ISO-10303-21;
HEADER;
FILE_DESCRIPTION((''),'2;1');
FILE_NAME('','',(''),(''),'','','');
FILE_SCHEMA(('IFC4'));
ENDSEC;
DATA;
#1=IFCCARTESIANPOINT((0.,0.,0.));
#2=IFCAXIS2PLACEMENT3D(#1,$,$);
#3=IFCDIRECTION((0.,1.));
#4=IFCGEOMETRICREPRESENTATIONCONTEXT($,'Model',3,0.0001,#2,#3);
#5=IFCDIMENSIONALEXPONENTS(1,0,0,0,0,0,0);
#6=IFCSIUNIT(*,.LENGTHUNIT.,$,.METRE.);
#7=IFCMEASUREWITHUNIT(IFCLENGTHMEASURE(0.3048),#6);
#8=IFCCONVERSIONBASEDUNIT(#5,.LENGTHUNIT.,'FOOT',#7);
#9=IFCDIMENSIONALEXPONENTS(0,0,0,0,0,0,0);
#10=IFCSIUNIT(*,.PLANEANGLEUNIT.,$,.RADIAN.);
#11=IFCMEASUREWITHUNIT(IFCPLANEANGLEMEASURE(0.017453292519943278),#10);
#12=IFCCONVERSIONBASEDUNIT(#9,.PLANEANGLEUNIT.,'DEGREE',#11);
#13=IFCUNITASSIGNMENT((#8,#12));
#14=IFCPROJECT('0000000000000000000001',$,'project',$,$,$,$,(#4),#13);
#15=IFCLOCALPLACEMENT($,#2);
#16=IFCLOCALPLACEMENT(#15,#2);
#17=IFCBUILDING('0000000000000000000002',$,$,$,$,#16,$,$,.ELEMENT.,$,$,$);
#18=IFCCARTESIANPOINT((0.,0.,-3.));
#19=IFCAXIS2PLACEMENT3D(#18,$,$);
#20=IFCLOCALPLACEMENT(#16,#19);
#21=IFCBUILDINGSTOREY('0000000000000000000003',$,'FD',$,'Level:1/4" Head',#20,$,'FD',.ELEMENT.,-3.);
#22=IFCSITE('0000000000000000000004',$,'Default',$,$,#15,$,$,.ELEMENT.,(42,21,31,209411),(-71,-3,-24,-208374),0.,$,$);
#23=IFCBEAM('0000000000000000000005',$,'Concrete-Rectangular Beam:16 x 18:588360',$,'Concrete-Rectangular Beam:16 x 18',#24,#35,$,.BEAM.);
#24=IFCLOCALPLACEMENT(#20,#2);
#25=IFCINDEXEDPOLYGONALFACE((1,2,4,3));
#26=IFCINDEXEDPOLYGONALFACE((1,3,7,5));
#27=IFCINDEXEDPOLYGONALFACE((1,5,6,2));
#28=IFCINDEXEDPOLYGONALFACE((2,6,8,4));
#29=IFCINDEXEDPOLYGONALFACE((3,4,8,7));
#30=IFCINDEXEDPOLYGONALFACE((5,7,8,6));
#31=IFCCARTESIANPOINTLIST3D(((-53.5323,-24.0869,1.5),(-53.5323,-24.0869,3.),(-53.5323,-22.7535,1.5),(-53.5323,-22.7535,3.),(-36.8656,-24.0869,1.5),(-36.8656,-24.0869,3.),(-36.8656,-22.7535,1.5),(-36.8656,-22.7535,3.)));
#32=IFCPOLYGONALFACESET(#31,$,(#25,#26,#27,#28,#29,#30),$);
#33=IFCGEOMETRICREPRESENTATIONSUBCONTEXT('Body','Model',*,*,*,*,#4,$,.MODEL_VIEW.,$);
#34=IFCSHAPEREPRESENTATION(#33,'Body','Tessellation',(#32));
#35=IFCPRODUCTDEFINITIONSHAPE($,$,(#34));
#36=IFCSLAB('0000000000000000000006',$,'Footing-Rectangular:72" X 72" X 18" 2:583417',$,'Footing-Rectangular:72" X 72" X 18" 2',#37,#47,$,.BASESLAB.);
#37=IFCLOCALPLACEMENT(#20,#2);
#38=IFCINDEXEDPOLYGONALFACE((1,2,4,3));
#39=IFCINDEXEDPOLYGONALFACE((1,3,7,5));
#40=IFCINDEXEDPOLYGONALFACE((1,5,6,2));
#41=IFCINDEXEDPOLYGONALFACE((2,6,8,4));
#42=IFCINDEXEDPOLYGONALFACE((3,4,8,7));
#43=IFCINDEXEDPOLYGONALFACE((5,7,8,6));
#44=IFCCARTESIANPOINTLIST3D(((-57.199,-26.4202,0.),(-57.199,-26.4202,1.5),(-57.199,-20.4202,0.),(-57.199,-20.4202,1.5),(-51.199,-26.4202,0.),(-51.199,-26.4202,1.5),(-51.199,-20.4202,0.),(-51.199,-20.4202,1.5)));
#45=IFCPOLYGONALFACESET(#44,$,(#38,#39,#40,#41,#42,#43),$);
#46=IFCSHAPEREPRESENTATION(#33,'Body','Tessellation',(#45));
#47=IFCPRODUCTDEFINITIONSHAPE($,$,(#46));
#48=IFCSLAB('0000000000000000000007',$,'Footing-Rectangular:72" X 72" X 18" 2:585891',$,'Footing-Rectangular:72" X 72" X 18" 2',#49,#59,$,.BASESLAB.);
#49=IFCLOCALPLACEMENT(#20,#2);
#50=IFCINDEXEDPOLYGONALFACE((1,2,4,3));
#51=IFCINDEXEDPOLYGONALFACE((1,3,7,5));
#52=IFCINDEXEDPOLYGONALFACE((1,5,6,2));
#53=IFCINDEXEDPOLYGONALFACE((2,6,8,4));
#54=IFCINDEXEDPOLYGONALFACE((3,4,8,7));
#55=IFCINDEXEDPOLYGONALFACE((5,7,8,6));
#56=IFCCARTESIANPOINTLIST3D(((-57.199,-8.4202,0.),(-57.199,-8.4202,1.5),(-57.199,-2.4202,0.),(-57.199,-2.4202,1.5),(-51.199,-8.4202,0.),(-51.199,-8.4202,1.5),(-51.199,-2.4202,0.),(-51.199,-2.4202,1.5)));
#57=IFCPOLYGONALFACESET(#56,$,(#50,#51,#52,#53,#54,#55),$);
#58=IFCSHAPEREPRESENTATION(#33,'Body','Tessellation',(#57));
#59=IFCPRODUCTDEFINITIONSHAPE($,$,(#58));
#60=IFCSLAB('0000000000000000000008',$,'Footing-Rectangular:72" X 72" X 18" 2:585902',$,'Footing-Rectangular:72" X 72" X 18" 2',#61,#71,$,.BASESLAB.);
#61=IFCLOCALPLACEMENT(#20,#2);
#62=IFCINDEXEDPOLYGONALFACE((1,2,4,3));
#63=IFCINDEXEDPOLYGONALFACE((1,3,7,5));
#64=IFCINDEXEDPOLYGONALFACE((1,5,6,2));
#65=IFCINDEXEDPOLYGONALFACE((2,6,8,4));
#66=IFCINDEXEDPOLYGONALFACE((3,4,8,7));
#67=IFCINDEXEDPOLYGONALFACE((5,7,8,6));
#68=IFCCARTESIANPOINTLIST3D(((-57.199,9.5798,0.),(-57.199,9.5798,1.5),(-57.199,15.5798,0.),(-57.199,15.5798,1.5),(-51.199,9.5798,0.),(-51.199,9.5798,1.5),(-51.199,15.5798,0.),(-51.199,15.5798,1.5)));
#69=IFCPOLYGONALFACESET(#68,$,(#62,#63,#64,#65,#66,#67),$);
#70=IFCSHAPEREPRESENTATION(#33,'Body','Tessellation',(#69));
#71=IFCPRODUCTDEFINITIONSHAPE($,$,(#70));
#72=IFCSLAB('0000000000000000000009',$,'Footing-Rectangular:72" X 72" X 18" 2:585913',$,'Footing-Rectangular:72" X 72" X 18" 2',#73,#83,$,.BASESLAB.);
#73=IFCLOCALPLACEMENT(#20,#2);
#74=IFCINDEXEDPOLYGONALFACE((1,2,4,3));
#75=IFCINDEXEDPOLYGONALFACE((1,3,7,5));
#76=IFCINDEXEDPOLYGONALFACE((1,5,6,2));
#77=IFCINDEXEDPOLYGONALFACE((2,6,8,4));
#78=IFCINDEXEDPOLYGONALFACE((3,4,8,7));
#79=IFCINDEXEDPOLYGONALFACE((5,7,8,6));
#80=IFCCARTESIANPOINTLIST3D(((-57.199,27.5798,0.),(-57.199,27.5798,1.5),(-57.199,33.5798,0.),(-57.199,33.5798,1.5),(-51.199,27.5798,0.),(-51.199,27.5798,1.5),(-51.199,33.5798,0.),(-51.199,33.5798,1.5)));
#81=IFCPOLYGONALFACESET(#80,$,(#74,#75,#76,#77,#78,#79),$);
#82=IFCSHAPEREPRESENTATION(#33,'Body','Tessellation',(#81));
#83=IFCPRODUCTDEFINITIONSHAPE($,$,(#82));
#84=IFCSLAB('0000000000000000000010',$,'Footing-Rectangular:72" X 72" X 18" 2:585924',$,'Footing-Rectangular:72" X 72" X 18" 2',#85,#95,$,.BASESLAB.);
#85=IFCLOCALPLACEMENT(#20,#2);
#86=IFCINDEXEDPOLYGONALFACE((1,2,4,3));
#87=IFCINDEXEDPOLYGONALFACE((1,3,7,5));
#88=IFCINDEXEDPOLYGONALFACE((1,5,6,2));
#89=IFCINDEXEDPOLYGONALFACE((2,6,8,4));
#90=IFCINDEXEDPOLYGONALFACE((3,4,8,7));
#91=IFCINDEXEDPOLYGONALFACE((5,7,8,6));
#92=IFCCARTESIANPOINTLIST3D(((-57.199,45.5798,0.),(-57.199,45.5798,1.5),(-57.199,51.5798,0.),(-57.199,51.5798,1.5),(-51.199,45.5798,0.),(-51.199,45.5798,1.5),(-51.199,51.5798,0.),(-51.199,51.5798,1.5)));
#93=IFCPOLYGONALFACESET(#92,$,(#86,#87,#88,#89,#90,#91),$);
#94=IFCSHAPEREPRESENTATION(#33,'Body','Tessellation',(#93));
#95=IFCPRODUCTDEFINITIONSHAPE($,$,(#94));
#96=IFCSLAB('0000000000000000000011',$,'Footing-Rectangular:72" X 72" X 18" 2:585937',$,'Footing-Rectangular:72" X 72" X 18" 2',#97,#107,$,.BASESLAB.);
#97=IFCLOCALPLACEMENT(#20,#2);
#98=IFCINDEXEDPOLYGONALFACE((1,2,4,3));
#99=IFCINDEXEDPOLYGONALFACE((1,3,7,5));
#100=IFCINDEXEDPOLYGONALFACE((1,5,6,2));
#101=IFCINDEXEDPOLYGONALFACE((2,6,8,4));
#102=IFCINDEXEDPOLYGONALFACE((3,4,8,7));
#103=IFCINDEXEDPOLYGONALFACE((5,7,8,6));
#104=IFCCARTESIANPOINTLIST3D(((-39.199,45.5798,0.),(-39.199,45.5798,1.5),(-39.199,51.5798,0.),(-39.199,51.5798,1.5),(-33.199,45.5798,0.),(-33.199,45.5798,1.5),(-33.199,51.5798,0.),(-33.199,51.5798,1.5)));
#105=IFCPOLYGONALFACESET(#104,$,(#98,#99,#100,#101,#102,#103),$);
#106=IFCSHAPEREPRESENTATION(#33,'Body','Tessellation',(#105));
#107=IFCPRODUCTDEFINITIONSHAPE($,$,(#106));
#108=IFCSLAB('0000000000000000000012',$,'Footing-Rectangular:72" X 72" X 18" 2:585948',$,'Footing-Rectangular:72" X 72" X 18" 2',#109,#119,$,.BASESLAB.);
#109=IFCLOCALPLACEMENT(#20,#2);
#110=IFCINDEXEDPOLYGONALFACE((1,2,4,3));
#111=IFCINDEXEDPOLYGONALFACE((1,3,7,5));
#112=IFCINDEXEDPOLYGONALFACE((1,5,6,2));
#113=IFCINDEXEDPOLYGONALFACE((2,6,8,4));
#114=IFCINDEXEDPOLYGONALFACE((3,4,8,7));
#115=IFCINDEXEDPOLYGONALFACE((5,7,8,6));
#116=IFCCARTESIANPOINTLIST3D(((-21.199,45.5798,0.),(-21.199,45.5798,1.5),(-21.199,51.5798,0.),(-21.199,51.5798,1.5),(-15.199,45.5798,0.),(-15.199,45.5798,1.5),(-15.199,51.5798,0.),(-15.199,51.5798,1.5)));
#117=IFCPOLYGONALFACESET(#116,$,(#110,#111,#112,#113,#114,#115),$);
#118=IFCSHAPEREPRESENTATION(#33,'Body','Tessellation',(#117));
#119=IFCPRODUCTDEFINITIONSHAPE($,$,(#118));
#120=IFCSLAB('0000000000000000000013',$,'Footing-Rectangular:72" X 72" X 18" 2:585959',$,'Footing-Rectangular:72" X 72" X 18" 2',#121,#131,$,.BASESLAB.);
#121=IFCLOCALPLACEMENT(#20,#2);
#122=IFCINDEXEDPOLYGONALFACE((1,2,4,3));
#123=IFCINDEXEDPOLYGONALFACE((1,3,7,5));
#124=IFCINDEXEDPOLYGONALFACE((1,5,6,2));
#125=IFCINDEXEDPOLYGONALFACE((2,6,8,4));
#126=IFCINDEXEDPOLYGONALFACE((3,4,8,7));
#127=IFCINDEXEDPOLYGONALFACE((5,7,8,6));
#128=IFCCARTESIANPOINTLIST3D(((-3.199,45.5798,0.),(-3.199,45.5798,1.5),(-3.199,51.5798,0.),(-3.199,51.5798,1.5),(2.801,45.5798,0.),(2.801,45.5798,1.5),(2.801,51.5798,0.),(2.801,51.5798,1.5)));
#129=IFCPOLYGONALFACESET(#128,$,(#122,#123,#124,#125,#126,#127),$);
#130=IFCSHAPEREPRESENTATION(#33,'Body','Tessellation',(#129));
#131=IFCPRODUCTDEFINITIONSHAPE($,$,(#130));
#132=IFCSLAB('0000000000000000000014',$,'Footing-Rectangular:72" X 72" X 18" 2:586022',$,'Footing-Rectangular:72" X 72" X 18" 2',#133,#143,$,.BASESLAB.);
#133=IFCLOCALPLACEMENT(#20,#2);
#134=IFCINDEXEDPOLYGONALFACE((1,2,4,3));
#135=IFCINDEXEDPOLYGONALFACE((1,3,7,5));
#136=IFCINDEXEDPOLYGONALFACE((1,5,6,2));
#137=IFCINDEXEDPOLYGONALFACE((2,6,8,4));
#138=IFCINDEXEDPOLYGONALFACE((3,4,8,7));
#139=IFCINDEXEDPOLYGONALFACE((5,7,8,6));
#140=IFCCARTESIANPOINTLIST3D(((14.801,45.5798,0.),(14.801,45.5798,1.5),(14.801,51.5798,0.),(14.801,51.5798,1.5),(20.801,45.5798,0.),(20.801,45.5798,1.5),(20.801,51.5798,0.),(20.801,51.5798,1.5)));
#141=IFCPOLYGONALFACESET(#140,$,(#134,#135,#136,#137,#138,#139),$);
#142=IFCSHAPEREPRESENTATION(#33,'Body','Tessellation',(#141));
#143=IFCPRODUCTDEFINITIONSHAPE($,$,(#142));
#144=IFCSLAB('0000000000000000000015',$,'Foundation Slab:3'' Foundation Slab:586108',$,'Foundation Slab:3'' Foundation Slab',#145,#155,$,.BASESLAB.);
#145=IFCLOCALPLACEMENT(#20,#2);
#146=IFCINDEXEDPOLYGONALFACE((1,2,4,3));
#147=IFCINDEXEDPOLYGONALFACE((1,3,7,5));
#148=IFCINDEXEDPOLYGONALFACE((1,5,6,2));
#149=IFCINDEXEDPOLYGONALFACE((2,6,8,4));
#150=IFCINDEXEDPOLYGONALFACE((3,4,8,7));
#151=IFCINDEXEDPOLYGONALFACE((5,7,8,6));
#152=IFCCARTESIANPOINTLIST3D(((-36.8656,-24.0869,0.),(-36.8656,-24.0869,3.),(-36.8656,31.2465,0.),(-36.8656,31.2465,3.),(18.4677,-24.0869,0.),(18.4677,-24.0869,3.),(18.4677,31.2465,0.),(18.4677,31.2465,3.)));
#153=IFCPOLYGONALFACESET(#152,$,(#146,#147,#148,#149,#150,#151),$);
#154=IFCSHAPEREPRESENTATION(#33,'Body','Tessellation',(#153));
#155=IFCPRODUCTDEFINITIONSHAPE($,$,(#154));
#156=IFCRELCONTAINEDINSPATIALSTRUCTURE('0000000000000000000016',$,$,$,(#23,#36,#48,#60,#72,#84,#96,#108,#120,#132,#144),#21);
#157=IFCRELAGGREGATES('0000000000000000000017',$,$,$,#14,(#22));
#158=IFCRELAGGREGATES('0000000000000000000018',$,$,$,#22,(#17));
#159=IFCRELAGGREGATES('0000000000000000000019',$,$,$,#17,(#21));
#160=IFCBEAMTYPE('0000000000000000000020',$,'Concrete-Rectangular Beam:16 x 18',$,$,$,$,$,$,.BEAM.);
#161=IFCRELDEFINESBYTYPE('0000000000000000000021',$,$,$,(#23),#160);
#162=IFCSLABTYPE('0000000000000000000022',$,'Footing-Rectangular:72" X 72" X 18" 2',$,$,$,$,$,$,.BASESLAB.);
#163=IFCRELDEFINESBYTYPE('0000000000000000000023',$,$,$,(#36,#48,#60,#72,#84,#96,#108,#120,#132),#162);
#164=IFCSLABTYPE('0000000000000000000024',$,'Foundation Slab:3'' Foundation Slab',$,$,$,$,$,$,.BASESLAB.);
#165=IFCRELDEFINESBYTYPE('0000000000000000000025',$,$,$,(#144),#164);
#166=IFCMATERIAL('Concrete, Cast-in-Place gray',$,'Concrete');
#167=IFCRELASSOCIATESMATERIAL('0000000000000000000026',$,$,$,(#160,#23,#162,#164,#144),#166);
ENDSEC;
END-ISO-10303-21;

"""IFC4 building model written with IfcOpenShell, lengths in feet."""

from ifc_helpers import new_model, entity, si_unit, converted_unit, direction, frame, origin, place, context, subcontext, project, spatial, indexed_curve, outline, extrude, source, transform, mapped, material, type_object, type_shapes, element, save


model = new_model("IFC4")

# Units and contexts
model_context = context("Model", 3, precision=0.0001, world=origin(), true_north=direction((0.0, 1.0)))
body_context = subcontext(model_context, "Body", "Model", "MODEL_VIEW")
ifc_project = project(units=[converted_unit("LENGTHUNIT", "FOOT", entity("IfcLengthMeasure", 0.3048), si_unit("LENGTHUNIT", "METRE"), dimensions=[1, 0, 0, 0, 0, 0, 0]), converted_unit("PLANEANGLEUNIT", "DEGREE", entity("IfcPlaneAngleMeasure", 0.017453292519943278), si_unit("PLANEANGLEUNIT", "RADIAN"), dimensions=[0, 0, 0, 0, 0, 0, 0])], contexts=[model_context])

# Site, building, storey
site_placement = place(None, origin())
site = spatial("IfcSite", under=ifc_project, at=site_placement, Name="Default", CompositionType="ELEMENT", RefLatitude=(42, 21, 31, 209411), RefLongitude=(-71, -3, -24, -208374), RefElevation=0.0)
building_placement = place(site_placement, origin())
building = spatial("IfcBuilding", under=site, at=building_placement, CompositionType="ELEMENT")
storey_placement = place(building_placement, frame((0.0, 0.0, -3.0)))
storey = spatial("IfcBuildingStorey", under=building, at=storey_placement, Name="FD", ObjectType="Level:1/4\" Head", LongName="FD", CompositionType="ELEMENT", Elevation=-3.0)

# Shared definitions
ifc_material = material(Name="Concrete, Cast-in-Place gray", Category="Concrete")

# Beam
beam_type_1 = type_object("IfcBeamType", Name="Concrete-Rectangular Beam:16 x 18", PredefinedType="BEAM", material=ifc_material)
shared_shape_1 = source(origin(), body_context, "Body", "SweptSolid", [
    extrude(outline(indexed_curve([(-0.75, -0.6667), (0.75, -0.6667), (0.75, 0.6667), (-0.75, 0.6667), (-0.75, -0.6667)], self_intersect=False)), frame((-53.5323, -23.4202, -0.75), z_axis=(1.0, 0.0, 0.0), x_axis=(0.0, 0.0, -1.0)), (0.0, 0.0, 1.0), 16.6667),
])
type_shapes(beam_type_1, [shared_shape_1])
beam_1_placement = place(storey_placement, frame((0.0, 0.0, 3.0)))
element("IfcBeam", 1, at=beam_1_placement, inside=storey, type_object=beam_type_1, material=ifc_material, Name="Concrete-Rectangular Beam:16 x 18:588360", ObjectType="Concrete-Rectangular Beam:16 x 18", PredefinedType="BEAM", context=body_context, shape_type="MappedRepresentation", body=[
    mapped(shared_shape_1, transform((0.0, 0.0, 0.0), scale=1.0)),
])

# Slabs
slab_type_1 = type_object("IfcSlabType", Name="Footing-Rectangular:72\" X 72\" X 18\" 2", PredefinedType="BASESLAB", material=ifc_material)
slab_1_placement = place(storey_placement, origin())
element("IfcSlab", 2, at=slab_1_placement, inside=storey, type_object=slab_type_1, Name="Footing-Rectangular:72\" X 72\" X 18\" 2:583417", ObjectType="Footing-Rectangular:72\" X 72\" X 18\" 2", PredefinedType="BASESLAB", context=body_context, shape_type="SweptSolid", body=[
    extrude(outline(indexed_curve([(-3.0, -3.0), (3.0, -3.0), (3.0, 3.0), (-3.0, 3.0), (-3.0, -3.0)], self_intersect=False)), frame((-54.199, -23.4202, 0.0), z_axis=(0.0, 0.0, 1.0), x_axis=(-1.0, 0.0, 0.0)), (0.0, 0.0, 1.0), 1.5),
])
slab_2_placement = place(storey_placement, origin())
element("IfcSlab", 3, at=slab_2_placement, inside=storey, type_object=slab_type_1, Name="Footing-Rectangular:72\" X 72\" X 18\" 2:585891", ObjectType="Footing-Rectangular:72\" X 72\" X 18\" 2", PredefinedType="BASESLAB", context=body_context, shape_type="SweptSolid", body=[
    extrude(outline(indexed_curve([(-3.0, -3.0), (3.0, -3.0), (3.0, 3.0), (-3.0, 3.0), (-3.0, -3.0)], self_intersect=False)), frame((-54.199, -5.4202, 0.0), z_axis=(0.0, 0.0, 1.0), x_axis=(-1.0, 0.0, 0.0)), (0.0, 0.0, 1.0), 1.5),
])
slab_3_placement = place(storey_placement, origin())
element("IfcSlab", 4, at=slab_3_placement, inside=storey, type_object=slab_type_1, Name="Footing-Rectangular:72\" X 72\" X 18\" 2:585902", ObjectType="Footing-Rectangular:72\" X 72\" X 18\" 2", PredefinedType="BASESLAB", context=body_context, shape_type="SweptSolid", body=[
    extrude(outline(indexed_curve([(-3.0, -3.0), (3.0, -3.0), (3.0, 3.0), (-3.0, 3.0), (-3.0, -3.0)], self_intersect=False)), frame((-54.199, 12.5798, 0.0), z_axis=(0.0, 0.0, 1.0), x_axis=(-1.0, 0.0, 0.0)), (0.0, 0.0, 1.0), 1.5),
])
slab_4_placement = place(storey_placement, origin())
element("IfcSlab", 5, at=slab_4_placement, inside=storey, type_object=slab_type_1, Name="Footing-Rectangular:72\" X 72\" X 18\" 2:585913", ObjectType="Footing-Rectangular:72\" X 72\" X 18\" 2", PredefinedType="BASESLAB", context=body_context, shape_type="SweptSolid", body=[
    extrude(outline(indexed_curve([(-3.0, -3.0), (3.0, -3.0), (3.0, 3.0), (-3.0, 3.0), (-3.0, -3.0)], self_intersect=False)), frame((-54.199, 30.5798, 0.0), z_axis=(0.0, 0.0, 1.0), x_axis=(-1.0, 0.0, 0.0)), (0.0, 0.0, 1.0), 1.5),
])
slab_5_placement = place(storey_placement, origin())
element("IfcSlab", 6, at=slab_5_placement, inside=storey, type_object=slab_type_1, Name="Footing-Rectangular:72\" X 72\" X 18\" 2:585924", ObjectType="Footing-Rectangular:72\" X 72\" X 18\" 2", PredefinedType="BASESLAB", context=body_context, shape_type="SweptSolid", body=[
    extrude(outline(indexed_curve([(-3.0, -3.0), (3.0, -3.0), (3.0, 3.0), (-3.0, 3.0), (-3.0, -3.0)], self_intersect=False)), frame((-54.199, 48.5798, 0.0), z_axis=(0.0, 0.0, 1.0), x_axis=(-1.0, 0.0, 0.0)), (0.0, 0.0, 1.0), 1.5),
])
slab_6_placement = place(storey_placement, origin())
element("IfcSlab", 7, at=slab_6_placement, inside=storey, type_object=slab_type_1, Name="Footing-Rectangular:72\" X 72\" X 18\" 2:585937", ObjectType="Footing-Rectangular:72\" X 72\" X 18\" 2", PredefinedType="BASESLAB", context=body_context, shape_type="SweptSolid", body=[
    extrude(outline(indexed_curve([(-3.0, -3.0), (3.0, -3.0), (3.0, 3.0), (-3.0, 3.0), (-3.0, -3.0)], self_intersect=False)), frame((-36.199, 48.5798, 0.0), z_axis=(0.0, 0.0, 1.0), x_axis=(-1.0, 0.0, 0.0)), (0.0, 0.0, 1.0), 1.5),
])
slab_7_placement = place(storey_placement, origin())
element("IfcSlab", 8, at=slab_7_placement, inside=storey, type_object=slab_type_1, Name="Footing-Rectangular:72\" X 72\" X 18\" 2:585948", ObjectType="Footing-Rectangular:72\" X 72\" X 18\" 2", PredefinedType="BASESLAB", context=body_context, shape_type="SweptSolid", body=[
    extrude(outline(indexed_curve([(-3.0, -3.0), (3.0, -3.0), (3.0, 3.0), (-3.0, 3.0), (-3.0, -3.0)], self_intersect=False)), frame((-18.199, 48.5798, 0.0), z_axis=(0.0, 0.0, 1.0), x_axis=(-1.0, 0.0, 0.0)), (0.0, 0.0, 1.0), 1.5),
])
slab_8_placement = place(storey_placement, origin())
element("IfcSlab", 9, at=slab_8_placement, inside=storey, type_object=slab_type_1, Name="Footing-Rectangular:72\" X 72\" X 18\" 2:585959", ObjectType="Footing-Rectangular:72\" X 72\" X 18\" 2", PredefinedType="BASESLAB", context=body_context, shape_type="SweptSolid", body=[
    extrude(outline(indexed_curve([(-3.0, -3.0), (3.0, -3.0), (3.0, 3.0), (-3.0, 3.0), (-3.0, -3.0)], self_intersect=False)), frame((-0.199, 48.5798, 0.0), z_axis=(0.0, 0.0, 1.0), x_axis=(-1.0, 0.0, 0.0)), (0.0, 0.0, 1.0), 1.5),
])
slab_9_placement = place(storey_placement, origin())
element("IfcSlab", 10, at=slab_9_placement, inside=storey, type_object=slab_type_1, Name="Footing-Rectangular:72\" X 72\" X 18\" 2:586022", ObjectType="Footing-Rectangular:72\" X 72\" X 18\" 2", PredefinedType="BASESLAB", context=body_context, shape_type="SweptSolid", body=[
    extrude(outline(indexed_curve([(-3.0, -3.0), (3.0, -3.0), (3.0, 3.0), (-3.0, 3.0), (-3.0, -3.0)], self_intersect=False)), frame((17.801, 48.5798, 0.0), z_axis=(0.0, 0.0, 1.0), x_axis=(-1.0, 0.0, 0.0)), (0.0, 0.0, 1.0), 1.5),
])
slab_type_2 = type_object("IfcSlabType", Name="Foundation Slab:3' Foundation Slab", PredefinedType="BASESLAB", material=ifc_material)
slab_10_placement = place(storey_placement, origin())
element("IfcSlab", 11, at=slab_10_placement, inside=storey, type_object=slab_type_2, material=ifc_material, Name="Foundation Slab:3' Foundation Slab:586108", ObjectType="Foundation Slab:3' Foundation Slab", PredefinedType="BASESLAB", context=body_context, shape_type="SweptSolid", body=[
    extrude(outline(indexed_curve([(-27.6667, -27.6667), (27.6667, -27.6667), (27.6667, 27.6667), (-27.6667, 27.6667), (-27.6667, -27.6667)], self_intersect=False)), frame((-9.199, 3.5798, 3.0), z_axis=(0.0, 0.0, -1.0), x_axis=(0.0, 1.0, 0.0)), (0.0, 0.0, 1.0), 3.0),
])

save(model, "model.ifc")
